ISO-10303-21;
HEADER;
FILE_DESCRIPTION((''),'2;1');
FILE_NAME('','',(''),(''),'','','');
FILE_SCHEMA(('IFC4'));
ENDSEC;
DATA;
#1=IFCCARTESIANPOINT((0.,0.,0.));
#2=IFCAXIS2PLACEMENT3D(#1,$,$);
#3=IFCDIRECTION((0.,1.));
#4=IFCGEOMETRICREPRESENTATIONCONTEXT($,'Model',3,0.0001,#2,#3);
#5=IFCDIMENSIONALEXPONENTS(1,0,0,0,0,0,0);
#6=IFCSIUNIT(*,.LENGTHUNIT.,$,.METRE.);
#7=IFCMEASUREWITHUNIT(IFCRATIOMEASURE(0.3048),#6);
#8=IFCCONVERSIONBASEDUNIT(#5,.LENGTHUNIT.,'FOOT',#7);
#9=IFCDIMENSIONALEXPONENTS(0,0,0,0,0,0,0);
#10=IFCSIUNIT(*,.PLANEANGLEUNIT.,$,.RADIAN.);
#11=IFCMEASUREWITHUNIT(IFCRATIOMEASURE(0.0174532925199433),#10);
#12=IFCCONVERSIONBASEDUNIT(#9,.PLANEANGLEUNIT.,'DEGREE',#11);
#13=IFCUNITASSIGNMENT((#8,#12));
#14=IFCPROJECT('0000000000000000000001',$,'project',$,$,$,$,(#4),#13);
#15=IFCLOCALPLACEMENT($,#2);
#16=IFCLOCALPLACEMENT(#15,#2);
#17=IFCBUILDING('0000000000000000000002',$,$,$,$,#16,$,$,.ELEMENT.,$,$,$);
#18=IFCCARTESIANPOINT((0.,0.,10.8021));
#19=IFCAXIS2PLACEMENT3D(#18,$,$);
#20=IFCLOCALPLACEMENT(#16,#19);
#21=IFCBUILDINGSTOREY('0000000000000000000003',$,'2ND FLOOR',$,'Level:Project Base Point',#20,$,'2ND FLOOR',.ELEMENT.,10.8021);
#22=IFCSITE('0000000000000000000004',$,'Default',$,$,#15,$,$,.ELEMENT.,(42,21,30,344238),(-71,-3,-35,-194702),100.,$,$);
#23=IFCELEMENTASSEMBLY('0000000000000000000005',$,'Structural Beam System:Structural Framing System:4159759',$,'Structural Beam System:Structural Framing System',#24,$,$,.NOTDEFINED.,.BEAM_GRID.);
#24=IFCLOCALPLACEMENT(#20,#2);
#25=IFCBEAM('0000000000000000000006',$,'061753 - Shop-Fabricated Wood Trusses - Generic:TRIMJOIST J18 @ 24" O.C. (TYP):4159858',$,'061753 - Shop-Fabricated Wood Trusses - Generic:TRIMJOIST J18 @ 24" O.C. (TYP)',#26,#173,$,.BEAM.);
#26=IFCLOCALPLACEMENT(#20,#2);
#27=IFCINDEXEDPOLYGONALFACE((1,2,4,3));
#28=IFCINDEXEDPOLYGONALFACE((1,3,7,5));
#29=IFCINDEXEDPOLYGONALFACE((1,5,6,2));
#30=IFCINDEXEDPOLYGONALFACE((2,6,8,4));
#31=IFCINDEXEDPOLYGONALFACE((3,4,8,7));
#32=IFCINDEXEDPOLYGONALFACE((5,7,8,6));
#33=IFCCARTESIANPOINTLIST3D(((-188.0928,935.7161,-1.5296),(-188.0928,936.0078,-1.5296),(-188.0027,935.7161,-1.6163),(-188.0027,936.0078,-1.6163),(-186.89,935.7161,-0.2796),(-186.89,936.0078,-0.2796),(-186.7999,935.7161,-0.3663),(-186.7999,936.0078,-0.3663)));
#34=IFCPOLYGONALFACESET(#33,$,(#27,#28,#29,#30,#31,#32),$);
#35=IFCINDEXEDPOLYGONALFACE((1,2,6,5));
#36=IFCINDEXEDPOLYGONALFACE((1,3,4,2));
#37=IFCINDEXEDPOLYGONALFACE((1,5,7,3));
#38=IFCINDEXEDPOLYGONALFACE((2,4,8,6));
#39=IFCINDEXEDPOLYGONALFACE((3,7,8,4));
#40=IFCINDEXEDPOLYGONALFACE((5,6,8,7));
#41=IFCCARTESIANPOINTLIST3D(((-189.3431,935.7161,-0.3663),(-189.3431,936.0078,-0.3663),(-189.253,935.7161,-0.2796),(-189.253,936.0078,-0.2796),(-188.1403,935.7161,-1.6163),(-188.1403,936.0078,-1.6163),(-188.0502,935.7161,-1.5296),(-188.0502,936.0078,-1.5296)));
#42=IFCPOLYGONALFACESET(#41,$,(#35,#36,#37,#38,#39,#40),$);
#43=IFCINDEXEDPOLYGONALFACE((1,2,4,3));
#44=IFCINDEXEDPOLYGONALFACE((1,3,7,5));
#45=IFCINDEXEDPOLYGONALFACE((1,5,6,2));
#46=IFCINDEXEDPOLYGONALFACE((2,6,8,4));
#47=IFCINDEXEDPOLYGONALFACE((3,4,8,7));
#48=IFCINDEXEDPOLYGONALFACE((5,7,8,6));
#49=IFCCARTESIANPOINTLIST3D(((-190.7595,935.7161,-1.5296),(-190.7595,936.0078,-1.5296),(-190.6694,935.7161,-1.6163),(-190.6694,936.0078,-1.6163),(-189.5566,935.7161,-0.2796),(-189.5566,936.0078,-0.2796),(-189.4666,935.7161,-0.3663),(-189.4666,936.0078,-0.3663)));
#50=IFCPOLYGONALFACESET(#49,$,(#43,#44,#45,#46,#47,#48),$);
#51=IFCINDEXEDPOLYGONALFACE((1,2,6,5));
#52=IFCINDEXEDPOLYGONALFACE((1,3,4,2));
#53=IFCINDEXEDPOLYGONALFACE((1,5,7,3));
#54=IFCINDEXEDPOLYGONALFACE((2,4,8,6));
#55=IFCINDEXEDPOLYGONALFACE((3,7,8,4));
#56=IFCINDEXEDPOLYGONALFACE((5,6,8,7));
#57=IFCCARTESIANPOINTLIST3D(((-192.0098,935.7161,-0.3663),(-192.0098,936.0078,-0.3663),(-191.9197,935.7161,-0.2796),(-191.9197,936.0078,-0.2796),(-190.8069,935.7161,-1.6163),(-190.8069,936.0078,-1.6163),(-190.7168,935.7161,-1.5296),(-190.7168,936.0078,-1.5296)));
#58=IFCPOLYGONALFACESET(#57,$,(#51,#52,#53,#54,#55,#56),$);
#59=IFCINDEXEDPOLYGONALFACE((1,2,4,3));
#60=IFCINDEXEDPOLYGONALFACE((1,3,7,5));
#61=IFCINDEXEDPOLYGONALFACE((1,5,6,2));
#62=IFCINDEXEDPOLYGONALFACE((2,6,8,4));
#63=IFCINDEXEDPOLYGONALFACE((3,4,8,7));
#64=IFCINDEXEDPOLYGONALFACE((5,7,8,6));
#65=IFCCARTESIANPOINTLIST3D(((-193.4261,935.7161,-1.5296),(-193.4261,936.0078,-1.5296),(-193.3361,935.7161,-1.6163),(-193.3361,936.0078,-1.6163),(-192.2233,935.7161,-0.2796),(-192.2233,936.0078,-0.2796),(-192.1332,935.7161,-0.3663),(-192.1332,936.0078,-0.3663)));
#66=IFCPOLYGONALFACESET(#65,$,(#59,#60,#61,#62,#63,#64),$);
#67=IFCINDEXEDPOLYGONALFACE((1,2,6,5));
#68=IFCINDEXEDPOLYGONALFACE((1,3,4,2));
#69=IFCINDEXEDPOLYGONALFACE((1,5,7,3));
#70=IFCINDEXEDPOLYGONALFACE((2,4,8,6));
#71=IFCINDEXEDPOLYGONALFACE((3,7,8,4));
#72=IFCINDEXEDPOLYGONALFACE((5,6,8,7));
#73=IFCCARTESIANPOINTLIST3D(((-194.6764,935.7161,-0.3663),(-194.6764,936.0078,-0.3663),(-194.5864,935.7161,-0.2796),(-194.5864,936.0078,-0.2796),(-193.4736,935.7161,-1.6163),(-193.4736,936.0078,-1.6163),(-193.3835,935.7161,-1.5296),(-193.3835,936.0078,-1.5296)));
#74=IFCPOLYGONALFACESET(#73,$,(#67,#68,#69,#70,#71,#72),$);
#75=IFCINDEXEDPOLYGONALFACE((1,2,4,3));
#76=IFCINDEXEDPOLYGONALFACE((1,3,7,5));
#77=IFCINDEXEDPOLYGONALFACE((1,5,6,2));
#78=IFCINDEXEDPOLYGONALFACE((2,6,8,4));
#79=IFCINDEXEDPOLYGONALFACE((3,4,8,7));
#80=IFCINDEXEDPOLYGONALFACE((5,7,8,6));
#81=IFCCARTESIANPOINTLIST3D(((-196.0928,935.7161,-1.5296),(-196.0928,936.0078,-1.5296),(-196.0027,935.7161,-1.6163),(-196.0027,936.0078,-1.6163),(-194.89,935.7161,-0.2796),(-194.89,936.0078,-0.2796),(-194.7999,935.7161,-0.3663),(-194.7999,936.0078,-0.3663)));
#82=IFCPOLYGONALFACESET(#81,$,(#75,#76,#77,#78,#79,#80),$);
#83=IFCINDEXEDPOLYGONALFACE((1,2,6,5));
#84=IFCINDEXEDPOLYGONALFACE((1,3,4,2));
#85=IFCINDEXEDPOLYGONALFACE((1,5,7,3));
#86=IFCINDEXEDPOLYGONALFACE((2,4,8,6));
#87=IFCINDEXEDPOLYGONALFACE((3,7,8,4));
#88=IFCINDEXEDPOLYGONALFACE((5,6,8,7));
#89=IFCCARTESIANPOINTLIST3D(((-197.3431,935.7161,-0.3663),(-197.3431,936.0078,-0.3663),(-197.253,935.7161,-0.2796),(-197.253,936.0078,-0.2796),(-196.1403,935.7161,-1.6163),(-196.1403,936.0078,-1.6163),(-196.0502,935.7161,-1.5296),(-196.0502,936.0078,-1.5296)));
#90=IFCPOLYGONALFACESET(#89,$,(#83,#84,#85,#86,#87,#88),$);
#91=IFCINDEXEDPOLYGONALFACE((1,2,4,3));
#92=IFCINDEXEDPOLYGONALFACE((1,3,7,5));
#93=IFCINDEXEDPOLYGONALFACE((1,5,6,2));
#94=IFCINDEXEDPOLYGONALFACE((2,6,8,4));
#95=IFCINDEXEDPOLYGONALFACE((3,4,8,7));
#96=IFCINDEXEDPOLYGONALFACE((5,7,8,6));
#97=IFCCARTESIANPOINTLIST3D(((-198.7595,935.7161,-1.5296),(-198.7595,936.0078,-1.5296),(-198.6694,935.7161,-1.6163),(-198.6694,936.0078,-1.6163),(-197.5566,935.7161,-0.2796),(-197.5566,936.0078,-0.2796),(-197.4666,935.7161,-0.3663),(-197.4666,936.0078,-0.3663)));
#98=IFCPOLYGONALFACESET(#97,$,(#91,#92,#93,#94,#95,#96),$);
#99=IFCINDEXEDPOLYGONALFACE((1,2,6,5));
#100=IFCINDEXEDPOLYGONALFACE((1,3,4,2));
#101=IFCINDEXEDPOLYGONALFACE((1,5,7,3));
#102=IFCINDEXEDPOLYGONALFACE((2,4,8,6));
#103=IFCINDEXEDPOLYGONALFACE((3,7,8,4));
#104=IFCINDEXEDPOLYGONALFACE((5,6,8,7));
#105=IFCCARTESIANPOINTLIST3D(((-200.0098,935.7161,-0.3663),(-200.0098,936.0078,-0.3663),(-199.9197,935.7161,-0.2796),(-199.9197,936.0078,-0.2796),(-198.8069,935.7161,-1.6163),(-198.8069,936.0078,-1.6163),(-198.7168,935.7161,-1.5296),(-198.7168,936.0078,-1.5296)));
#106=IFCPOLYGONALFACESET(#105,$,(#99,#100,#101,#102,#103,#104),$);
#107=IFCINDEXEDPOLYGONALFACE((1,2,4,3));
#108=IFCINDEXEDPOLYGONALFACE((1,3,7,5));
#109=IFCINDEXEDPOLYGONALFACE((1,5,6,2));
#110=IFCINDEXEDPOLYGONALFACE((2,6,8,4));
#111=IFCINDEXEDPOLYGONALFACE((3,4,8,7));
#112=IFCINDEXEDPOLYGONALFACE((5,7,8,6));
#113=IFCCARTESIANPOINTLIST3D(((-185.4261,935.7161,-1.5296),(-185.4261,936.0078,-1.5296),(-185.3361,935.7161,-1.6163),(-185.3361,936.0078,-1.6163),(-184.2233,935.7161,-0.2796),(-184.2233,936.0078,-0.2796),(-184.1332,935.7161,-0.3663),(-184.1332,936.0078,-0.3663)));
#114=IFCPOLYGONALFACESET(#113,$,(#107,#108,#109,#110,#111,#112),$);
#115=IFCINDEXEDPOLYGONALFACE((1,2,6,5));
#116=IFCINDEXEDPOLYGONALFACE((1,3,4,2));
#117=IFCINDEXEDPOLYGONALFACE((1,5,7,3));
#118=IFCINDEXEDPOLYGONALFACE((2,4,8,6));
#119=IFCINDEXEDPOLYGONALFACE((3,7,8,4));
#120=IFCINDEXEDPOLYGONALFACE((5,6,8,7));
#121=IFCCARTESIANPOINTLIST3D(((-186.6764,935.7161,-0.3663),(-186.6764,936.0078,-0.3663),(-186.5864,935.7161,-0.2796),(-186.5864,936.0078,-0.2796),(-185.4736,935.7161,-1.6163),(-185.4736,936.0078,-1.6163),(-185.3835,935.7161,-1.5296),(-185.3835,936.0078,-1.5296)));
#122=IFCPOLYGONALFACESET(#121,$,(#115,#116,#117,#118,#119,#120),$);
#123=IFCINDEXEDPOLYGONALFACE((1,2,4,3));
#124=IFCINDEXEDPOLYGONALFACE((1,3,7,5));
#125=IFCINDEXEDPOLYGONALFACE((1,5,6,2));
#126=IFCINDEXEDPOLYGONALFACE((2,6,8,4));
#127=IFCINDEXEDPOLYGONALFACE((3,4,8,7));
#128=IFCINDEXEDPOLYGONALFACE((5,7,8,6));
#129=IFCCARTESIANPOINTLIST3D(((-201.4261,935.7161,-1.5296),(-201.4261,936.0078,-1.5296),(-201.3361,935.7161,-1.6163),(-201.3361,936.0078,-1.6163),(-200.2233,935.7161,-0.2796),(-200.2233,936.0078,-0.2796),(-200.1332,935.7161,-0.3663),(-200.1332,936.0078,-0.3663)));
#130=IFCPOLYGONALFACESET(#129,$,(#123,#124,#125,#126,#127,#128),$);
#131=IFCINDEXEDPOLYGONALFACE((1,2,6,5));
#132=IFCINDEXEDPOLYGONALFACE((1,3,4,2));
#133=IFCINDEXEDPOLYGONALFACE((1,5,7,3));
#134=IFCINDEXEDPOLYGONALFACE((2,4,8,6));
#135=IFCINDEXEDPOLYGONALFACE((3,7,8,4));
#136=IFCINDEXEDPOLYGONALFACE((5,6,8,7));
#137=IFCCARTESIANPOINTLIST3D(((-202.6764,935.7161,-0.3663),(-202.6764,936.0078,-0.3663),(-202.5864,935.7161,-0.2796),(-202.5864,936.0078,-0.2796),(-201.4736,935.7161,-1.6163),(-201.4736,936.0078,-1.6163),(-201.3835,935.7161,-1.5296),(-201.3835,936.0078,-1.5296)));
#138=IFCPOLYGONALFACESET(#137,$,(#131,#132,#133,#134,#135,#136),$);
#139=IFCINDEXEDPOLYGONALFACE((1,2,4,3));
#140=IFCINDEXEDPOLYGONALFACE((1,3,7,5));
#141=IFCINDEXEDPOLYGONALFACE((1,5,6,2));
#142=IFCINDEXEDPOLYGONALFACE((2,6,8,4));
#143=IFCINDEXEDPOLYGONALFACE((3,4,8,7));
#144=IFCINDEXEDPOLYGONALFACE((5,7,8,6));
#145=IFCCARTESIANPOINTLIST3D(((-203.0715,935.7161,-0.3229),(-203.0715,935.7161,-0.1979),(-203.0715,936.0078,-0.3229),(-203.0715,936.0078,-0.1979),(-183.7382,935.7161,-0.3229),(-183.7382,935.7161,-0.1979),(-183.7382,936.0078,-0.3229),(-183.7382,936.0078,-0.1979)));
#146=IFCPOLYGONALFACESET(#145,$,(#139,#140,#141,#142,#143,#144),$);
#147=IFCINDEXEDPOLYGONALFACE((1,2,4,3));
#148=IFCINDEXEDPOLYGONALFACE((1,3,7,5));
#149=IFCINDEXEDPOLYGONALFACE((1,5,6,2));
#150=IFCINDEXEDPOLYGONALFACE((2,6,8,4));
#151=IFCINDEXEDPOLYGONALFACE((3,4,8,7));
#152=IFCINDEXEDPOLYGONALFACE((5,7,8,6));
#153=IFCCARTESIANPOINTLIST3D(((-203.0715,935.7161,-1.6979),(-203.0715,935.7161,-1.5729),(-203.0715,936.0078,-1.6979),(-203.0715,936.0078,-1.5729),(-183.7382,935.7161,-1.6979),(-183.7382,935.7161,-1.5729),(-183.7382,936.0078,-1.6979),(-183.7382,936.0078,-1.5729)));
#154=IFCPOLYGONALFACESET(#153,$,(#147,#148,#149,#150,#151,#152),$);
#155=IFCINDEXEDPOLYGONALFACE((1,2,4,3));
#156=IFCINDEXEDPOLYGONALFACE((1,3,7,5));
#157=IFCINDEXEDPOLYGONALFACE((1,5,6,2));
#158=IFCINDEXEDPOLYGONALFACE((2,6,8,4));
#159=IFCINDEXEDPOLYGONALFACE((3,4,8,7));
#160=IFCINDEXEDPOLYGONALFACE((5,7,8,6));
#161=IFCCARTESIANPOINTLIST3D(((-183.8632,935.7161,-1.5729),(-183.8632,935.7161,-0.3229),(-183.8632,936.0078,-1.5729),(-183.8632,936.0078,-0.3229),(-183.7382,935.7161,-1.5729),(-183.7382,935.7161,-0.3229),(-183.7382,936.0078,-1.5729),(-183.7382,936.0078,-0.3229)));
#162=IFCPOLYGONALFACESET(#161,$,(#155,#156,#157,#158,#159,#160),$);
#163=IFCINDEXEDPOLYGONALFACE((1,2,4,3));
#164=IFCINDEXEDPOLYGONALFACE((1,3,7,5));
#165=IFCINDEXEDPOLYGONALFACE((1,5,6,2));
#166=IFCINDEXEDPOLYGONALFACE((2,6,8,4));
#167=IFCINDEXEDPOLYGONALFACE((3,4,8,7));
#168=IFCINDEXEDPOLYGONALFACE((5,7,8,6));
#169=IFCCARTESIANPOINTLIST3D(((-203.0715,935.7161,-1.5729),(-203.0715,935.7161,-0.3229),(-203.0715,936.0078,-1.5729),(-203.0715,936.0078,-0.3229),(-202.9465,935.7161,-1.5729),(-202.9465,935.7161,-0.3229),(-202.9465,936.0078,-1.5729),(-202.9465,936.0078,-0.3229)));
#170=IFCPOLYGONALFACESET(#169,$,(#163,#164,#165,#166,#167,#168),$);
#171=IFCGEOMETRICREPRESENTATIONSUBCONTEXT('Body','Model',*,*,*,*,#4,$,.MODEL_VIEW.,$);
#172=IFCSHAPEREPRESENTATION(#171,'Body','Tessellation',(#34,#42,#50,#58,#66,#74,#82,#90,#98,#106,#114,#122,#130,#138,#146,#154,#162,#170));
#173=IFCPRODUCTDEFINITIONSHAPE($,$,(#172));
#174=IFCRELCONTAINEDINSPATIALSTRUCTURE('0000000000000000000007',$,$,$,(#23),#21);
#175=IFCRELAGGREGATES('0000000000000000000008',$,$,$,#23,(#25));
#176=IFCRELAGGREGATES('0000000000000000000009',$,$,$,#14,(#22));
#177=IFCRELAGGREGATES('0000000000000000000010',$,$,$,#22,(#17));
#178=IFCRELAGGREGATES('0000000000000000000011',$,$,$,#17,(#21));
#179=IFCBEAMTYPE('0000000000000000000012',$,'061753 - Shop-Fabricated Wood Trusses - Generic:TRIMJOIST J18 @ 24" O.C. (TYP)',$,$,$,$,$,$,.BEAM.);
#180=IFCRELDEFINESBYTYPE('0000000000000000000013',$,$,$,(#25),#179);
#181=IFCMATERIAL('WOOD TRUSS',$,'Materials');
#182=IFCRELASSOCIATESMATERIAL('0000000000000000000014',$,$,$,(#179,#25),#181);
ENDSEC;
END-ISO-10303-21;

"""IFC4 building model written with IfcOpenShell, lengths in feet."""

from ifc_helpers import new_model, entity, si_unit, converted_unit, direction, frame, frame_2d, origin, origin_2d_with_axis, place, context, subcontext, project, spatial, rectangle, extrude, source, transform, mapped, material, material_profile, profile_set, profile_usage, type_object, type_shapes, element, aggregate, save


model = new_model("IFC4")

# Units and contexts
model_context = context("Model", 3, precision=0.0001, world=origin(), true_north=direction((0.0, 1.0)))
body_context = subcontext(model_context, "Body", "Model", "MODEL_VIEW")
ifc_project = project(units=[converted_unit("LENGTHUNIT", "FOOT", entity("IfcRatioMeasure", 0.3048), si_unit("LENGTHUNIT", "METRE"), dimensions=[1, 0, 0, 0, 0, 0, 0]), converted_unit("PLANEANGLEUNIT", "DEGREE", entity("IfcRatioMeasure", 0.0174532925199433), si_unit("PLANEANGLEUNIT", "RADIAN"), dimensions=[0, 0, 0, 0, 0, 0, 0])], contexts=[model_context])

# Site, building, storey
site_placement = place(None, origin())
site = spatial("IfcSite", under=ifc_project, at=site_placement, Name="Default", CompositionType="ELEMENT", RefLatitude=(42, 21, 30, 344238), RefLongitude=(-71, -3, -35, -194702), RefElevation=100.0)
building_placement = place(site_placement, origin())
building = spatial("IfcBuilding", under=site, at=building_placement, CompositionType="ELEMENT")
storey_placement = place(building_placement, frame((0.0, 0.0, 10.8021)))
storey = spatial("IfcBuildingStorey", under=building, at=storey_placement, Name="2ND FLOOR", ObjectType="Level:Project Base Point", LongName="2ND FLOOR", CompositionType="ELEMENT", Elevation=10.8021)

# Element assembly, beam
ifc_material_1 = material(Name="WOOD TRUSS", Category="Materials")
ifc_material_profile_1 = material_profile(ifc_material_1, rectangle(XDim=1.7347, YDim=0.125, at=frame_2d((0.0, 0.0), x_axis=(1.0, 0.0))), Name="TRIMJOIST J18 @ 24\" O.C. (TYP)")
ifc_material_profile_2 = material_profile(ifc_material_1, rectangle(XDim=1.7347, YDim=0.125, at=frame_2d((0.0, 0.0), x_axis=(1.0, 0.0))), Name="TRIMJOIST J18 @ 24\" O.C. (TYP)")
ifc_material_profile_3 = material_profile(ifc_material_1, rectangle(XDim=1.7347, YDim=0.125, at=frame_2d((0.0, 0.0), x_axis=(1.0, 0.0))), Name="TRIMJOIST J18 @ 24\" O.C. (TYP)")
ifc_material_profile_4 = material_profile(ifc_material_1, rectangle(XDim=1.7347, YDim=0.125, at=frame_2d((0.0, 0.0), x_axis=(1.0, 0.0))), Name="TRIMJOIST J18 @ 24\" O.C. (TYP)")
ifc_material_profile_5 = material_profile(ifc_material_1, rectangle(XDim=1.7347, YDim=0.125, at=frame_2d((0.0, 0.0), x_axis=(1.0, 0.0))), Name="TRIMJOIST J18 @ 24\" O.C. (TYP)")
ifc_material_profile_6 = material_profile(ifc_material_1, rectangle(XDim=1.7347, YDim=0.125, at=frame_2d((0.0, 0.0), x_axis=(1.0, 0.0))), Name="TRIMJOIST J18 @ 24\" O.C. (TYP)")
ifc_material_profile_7 = material_profile(ifc_material_1, rectangle(XDim=1.7347, YDim=0.125, at=frame_2d((0.0, 0.0), x_axis=(1.0, 0.0))), Name="TRIMJOIST J18 @ 24\" O.C. (TYP)")
ifc_material_profile_8 = material_profile(ifc_material_1, rectangle(XDim=1.7347, YDim=0.125, at=frame_2d((0.0, 0.0), x_axis=(1.0, 0.0))), Name="TRIMJOIST J18 @ 24\" O.C. (TYP)")
ifc_material_profile_9 = material_profile(ifc_material_1, rectangle(XDim=1.7347, YDim=0.125, at=frame_2d((0.0, 0.0), x_axis=(1.0, 0.0))), Name="TRIMJOIST J18 @ 24\" O.C. (TYP)")
ifc_material_profile_10 = material_profile(ifc_material_1, rectangle(XDim=1.7347, YDim=0.125, at=origin_2d_with_axis()), Name="TRIMJOIST J18 @ 24\" O.C. (TYP)")
ifc_material_profile_11 = material_profile(ifc_material_1, rectangle(XDim=0.125, YDim=0.2917, at=origin_2d_with_axis()), Name="TRIMJOIST J18 @ 24\" O.C. (TYP)")
ifc_material_profile_12 = material_profile(ifc_material_1, rectangle(XDim=0.125, YDim=0.2917, at=origin_2d_with_axis()), Name="TRIMJOIST J18 @ 24\" O.C. (TYP)")
ifc_material_profile_13 = material_profile(ifc_material_1, rectangle(XDim=1.25, YDim=0.2917, at=origin_2d_with_axis()), Name="TRIMJOIST J18 @ 24\" O.C. (TYP)")
ifc_material_profile_14 = material_profile(ifc_material_1, rectangle(XDim=1.25, YDim=0.2917, at=origin_2d_with_axis()), Name="TRIMJOIST J18 @ 24\" O.C. (TYP)")
ifc_profile_set_1 = profile_set([ifc_material_profile_1, ifc_material_profile_2, ifc_material_profile_3, ifc_material_profile_4, ifc_material_profile_5, ifc_material_profile_6, ifc_material_profile_7, ifc_material_profile_8, ifc_material_profile_9, ifc_material_profile_10, ifc_material_profile_11, ifc_material_profile_12, ifc_material_profile_13, ifc_material_profile_14], Name="TRIMJOIST J18 @ 24\" O.C. (TYP)")
beam_type_1 = type_object("IfcBeamType", Name="061753 - Shop-Fabricated Wood Trusses - Generic:TRIMJOIST J18 @ 24\" O.C. (TYP)", PredefinedType="BEAM", material=ifc_profile_set_1)
shared_shape_1 = source(origin(), body_context, "Body", "SweptSolid", [
    extrude(rectangle(XDim=1.7347, YDim=0.125, at=frame_2d((0.0, 0.0), x_axis=(1.0, 0.0))), frame((5.9585, -0.1458, 0.0), z_axis=(0.0, 1.0, 0.0), x_axis=(0.693383, 0.0, 0.720569)), (0.0, 0.0, 1.0), 0.2917),
    extrude(rectangle(XDim=1.7347, YDim=0.125, at=origin_2d_with_axis()), frame((4.7082, -0.1458, 0.0), z_axis=(0.0, 1.0, 0.0), x_axis=(0.693383, 0.0, -0.720569)), (0.0, 0.0, 1.0), 0.2917),
    extrude(rectangle(XDim=1.7347, YDim=0.125, at=frame_2d((0.0, 0.0), x_axis=(1.0, 0.0))), frame((3.2918, -0.1458, 0.0), z_axis=(0.0, 1.0, 0.0), x_axis=(0.693383, 0.0, 0.720569)), (0.0, 0.0, 1.0), 0.2917),
    extrude(rectangle(XDim=1.7347, YDim=0.125, at=frame_2d((0.0, 0.0), x_axis=(1.0, 0.0))), frame((2.0415, -0.1458, 0.0), z_axis=(0.0, 1.0, 0.0), x_axis=(0.693383, 0.0, -0.720569)), (0.0, 0.0, 1.0), 0.2917),
    extrude(rectangle(XDim=1.7347, YDim=0.125, at=frame_2d((0.0, 0.0), x_axis=(1.0, 0.0))), frame((0.6251, -0.1458, 0.0), z_axis=(0.0, 1.0, 0.0), x_axis=(0.693383, 0.0, 0.720569)), (0.0, 0.0, 1.0), 0.2917),
    extrude(rectangle(XDim=1.7347, YDim=0.125, at=frame_2d((0.0, 0.0), x_axis=(1.0, 0.0))), frame((-0.6251, -0.1458, 0.0), z_axis=(0.0, 1.0, 0.0), x_axis=(0.693383, 0.0, -0.720569)), (0.0, 0.0, 1.0), 0.2917),
    extrude(rectangle(XDim=1.7347, YDim=0.125, at=frame_2d((0.0, 0.0), x_axis=(1.0, 0.0))), frame((-2.0415, -0.1458, 0.0), z_axis=(0.0, 1.0, 0.0), x_axis=(0.693383, 0.0, 0.720569)), (0.0, 0.0, 1.0), 0.2917),
    extrude(rectangle(XDim=1.7347, YDim=0.125, at=origin_2d_with_axis()), frame((-3.2918, -0.1458, 0.0), z_axis=(0.0, 1.0, 0.0), x_axis=(0.693383, 0.0, -0.720569)), (0.0, 0.0, 1.0), 0.2917),
    extrude(rectangle(XDim=1.7347, YDim=0.125, at=frame_2d((0.0, 0.0), x_axis=(1.0, 0.0))), frame((-4.7082, -0.1458, 0.0), z_axis=(0.0, 1.0, 0.0), x_axis=(0.693383, 0.0, 0.720569)), (0.0, 0.0, 1.0), 0.2917),
    extrude(rectangle(XDim=1.7347, YDim=0.125, at=frame_2d((0.0, 0.0), x_axis=(1.0, 0.0))), frame((-5.9585, -0.1458, 0.0), z_axis=(0.0, 1.0, 0.0), x_axis=(0.693383, 0.0, -0.720569)), (0.0, 0.0, 1.0), 0.2917),
    extrude(rectangle(XDim=1.7347, YDim=0.125, at=frame_2d((0.0, 0.0), x_axis=(1.0, 0.0))), frame((8.6251, -0.1458, 0.0), z_axis=(0.0, 1.0, 0.0), x_axis=(0.693383, 0.0, 0.720569)), (0.0, 0.0, 1.0), 0.2917),
    extrude(rectangle(XDim=1.7347, YDim=0.125, at=origin_2d_with_axis()), frame((7.3749, -0.1458, 0.0), z_axis=(0.0, 1.0, 0.0), x_axis=(0.693383, 0.0, -0.720569)), (0.0, 0.0, 1.0), 0.2917),
    extrude(rectangle(XDim=1.7347, YDim=0.125, at=frame_2d((0.0, 0.0), x_axis=(1.0, 0.0))), frame((-7.3749, -0.1458, 0.0), z_axis=(0.0, 1.0, 0.0), x_axis=(0.693383, 0.0, 0.720569)), (0.0, 0.0, 1.0), 0.2917),
    extrude(rectangle(XDim=1.7347, YDim=0.125, at=origin_2d_with_axis()), frame((-8.6251, -0.1458, 0.0), z_axis=(0.0, 1.0, 0.0), x_axis=(0.693383, 0.0, -0.720569)), (0.0, 0.0, 1.0), 0.2917),
    extrude(rectangle(XDim=0.125, YDim=0.2917, at=origin_2d_with_axis()), frame((-9.6667, 0.0, 0.6875), z_axis=(1.0, 0.0, 0.0), x_axis=(0.0, 0.0, -1.0)), (0.0, 0.0, 1.0), 19.3333),
    extrude(rectangle(XDim=0.125, YDim=0.2917, at=origin_2d_with_axis()), frame((-9.6667, 0.0, -0.6875), z_axis=(1.0, 0.0, 0.0), x_axis=(0.0, 0.0, -1.0)), (0.0, 0.0, 1.0), 19.3333),
    extrude(rectangle(XDim=1.25, YDim=0.2917, at=origin_2d_with_axis()), frame((9.5417, 0.0, 0.0), z_axis=(1.0, 0.0, 0.0), x_axis=(0.0, 0.0, -1.0)), (0.0, 0.0, 1.0), 0.125),
    extrude(rectangle(XDim=1.25, YDim=0.2917, at=origin_2d_with_axis()), frame((-9.6667, 0.0, 0.0), z_axis=(1.0, 0.0, 0.0), x_axis=(0.0, 0.0, -1.0)), (0.0, 0.0, 1.0), 0.125),
])
type_shapes(beam_type_1, [shared_shape_1])
assembly_1_placement = place(storey_placement, origin())
assembly_1 = element("IfcElementAssembly", 1, at=assembly_1_placement, inside=storey, Name="Structural Beam System:Structural Framing System:4159759", ObjectType="Structural Beam System:Structural Framing System", AssemblyPlace="NOTDEFINED", PredefinedType="BEAM_GRID")
ifc_profile_usage_1 = profile_usage(ifc_profile_set_1, cardinal=8)
beam_1_placement = place(assembly_1_placement, frame((-193.4048, 935.8619, -0.9479)))
beam_1 = element("IfcBeam", 2, at=beam_1_placement, type_object=beam_type_1, material=ifc_profile_usage_1, Name="061753 - Shop-Fabricated Wood Trusses - Generic:TRIMJOIST J18 @ 24\" O.C. (TYP):4159858", ObjectType="061753 - Shop-Fabricated Wood Trusses - Generic:TRIMJOIST J18 @ 24\" O.C. (TYP)", PredefinedType="BEAM", context=body_context, shape_type="MappedRepresentation", body=[
    mapped(shared_shape_1, transform((0.0, 0.0, 0.0), scale=1.0)),
])
aggregate(assembly_1, [beam_1])

save(model, "model.ifc")
